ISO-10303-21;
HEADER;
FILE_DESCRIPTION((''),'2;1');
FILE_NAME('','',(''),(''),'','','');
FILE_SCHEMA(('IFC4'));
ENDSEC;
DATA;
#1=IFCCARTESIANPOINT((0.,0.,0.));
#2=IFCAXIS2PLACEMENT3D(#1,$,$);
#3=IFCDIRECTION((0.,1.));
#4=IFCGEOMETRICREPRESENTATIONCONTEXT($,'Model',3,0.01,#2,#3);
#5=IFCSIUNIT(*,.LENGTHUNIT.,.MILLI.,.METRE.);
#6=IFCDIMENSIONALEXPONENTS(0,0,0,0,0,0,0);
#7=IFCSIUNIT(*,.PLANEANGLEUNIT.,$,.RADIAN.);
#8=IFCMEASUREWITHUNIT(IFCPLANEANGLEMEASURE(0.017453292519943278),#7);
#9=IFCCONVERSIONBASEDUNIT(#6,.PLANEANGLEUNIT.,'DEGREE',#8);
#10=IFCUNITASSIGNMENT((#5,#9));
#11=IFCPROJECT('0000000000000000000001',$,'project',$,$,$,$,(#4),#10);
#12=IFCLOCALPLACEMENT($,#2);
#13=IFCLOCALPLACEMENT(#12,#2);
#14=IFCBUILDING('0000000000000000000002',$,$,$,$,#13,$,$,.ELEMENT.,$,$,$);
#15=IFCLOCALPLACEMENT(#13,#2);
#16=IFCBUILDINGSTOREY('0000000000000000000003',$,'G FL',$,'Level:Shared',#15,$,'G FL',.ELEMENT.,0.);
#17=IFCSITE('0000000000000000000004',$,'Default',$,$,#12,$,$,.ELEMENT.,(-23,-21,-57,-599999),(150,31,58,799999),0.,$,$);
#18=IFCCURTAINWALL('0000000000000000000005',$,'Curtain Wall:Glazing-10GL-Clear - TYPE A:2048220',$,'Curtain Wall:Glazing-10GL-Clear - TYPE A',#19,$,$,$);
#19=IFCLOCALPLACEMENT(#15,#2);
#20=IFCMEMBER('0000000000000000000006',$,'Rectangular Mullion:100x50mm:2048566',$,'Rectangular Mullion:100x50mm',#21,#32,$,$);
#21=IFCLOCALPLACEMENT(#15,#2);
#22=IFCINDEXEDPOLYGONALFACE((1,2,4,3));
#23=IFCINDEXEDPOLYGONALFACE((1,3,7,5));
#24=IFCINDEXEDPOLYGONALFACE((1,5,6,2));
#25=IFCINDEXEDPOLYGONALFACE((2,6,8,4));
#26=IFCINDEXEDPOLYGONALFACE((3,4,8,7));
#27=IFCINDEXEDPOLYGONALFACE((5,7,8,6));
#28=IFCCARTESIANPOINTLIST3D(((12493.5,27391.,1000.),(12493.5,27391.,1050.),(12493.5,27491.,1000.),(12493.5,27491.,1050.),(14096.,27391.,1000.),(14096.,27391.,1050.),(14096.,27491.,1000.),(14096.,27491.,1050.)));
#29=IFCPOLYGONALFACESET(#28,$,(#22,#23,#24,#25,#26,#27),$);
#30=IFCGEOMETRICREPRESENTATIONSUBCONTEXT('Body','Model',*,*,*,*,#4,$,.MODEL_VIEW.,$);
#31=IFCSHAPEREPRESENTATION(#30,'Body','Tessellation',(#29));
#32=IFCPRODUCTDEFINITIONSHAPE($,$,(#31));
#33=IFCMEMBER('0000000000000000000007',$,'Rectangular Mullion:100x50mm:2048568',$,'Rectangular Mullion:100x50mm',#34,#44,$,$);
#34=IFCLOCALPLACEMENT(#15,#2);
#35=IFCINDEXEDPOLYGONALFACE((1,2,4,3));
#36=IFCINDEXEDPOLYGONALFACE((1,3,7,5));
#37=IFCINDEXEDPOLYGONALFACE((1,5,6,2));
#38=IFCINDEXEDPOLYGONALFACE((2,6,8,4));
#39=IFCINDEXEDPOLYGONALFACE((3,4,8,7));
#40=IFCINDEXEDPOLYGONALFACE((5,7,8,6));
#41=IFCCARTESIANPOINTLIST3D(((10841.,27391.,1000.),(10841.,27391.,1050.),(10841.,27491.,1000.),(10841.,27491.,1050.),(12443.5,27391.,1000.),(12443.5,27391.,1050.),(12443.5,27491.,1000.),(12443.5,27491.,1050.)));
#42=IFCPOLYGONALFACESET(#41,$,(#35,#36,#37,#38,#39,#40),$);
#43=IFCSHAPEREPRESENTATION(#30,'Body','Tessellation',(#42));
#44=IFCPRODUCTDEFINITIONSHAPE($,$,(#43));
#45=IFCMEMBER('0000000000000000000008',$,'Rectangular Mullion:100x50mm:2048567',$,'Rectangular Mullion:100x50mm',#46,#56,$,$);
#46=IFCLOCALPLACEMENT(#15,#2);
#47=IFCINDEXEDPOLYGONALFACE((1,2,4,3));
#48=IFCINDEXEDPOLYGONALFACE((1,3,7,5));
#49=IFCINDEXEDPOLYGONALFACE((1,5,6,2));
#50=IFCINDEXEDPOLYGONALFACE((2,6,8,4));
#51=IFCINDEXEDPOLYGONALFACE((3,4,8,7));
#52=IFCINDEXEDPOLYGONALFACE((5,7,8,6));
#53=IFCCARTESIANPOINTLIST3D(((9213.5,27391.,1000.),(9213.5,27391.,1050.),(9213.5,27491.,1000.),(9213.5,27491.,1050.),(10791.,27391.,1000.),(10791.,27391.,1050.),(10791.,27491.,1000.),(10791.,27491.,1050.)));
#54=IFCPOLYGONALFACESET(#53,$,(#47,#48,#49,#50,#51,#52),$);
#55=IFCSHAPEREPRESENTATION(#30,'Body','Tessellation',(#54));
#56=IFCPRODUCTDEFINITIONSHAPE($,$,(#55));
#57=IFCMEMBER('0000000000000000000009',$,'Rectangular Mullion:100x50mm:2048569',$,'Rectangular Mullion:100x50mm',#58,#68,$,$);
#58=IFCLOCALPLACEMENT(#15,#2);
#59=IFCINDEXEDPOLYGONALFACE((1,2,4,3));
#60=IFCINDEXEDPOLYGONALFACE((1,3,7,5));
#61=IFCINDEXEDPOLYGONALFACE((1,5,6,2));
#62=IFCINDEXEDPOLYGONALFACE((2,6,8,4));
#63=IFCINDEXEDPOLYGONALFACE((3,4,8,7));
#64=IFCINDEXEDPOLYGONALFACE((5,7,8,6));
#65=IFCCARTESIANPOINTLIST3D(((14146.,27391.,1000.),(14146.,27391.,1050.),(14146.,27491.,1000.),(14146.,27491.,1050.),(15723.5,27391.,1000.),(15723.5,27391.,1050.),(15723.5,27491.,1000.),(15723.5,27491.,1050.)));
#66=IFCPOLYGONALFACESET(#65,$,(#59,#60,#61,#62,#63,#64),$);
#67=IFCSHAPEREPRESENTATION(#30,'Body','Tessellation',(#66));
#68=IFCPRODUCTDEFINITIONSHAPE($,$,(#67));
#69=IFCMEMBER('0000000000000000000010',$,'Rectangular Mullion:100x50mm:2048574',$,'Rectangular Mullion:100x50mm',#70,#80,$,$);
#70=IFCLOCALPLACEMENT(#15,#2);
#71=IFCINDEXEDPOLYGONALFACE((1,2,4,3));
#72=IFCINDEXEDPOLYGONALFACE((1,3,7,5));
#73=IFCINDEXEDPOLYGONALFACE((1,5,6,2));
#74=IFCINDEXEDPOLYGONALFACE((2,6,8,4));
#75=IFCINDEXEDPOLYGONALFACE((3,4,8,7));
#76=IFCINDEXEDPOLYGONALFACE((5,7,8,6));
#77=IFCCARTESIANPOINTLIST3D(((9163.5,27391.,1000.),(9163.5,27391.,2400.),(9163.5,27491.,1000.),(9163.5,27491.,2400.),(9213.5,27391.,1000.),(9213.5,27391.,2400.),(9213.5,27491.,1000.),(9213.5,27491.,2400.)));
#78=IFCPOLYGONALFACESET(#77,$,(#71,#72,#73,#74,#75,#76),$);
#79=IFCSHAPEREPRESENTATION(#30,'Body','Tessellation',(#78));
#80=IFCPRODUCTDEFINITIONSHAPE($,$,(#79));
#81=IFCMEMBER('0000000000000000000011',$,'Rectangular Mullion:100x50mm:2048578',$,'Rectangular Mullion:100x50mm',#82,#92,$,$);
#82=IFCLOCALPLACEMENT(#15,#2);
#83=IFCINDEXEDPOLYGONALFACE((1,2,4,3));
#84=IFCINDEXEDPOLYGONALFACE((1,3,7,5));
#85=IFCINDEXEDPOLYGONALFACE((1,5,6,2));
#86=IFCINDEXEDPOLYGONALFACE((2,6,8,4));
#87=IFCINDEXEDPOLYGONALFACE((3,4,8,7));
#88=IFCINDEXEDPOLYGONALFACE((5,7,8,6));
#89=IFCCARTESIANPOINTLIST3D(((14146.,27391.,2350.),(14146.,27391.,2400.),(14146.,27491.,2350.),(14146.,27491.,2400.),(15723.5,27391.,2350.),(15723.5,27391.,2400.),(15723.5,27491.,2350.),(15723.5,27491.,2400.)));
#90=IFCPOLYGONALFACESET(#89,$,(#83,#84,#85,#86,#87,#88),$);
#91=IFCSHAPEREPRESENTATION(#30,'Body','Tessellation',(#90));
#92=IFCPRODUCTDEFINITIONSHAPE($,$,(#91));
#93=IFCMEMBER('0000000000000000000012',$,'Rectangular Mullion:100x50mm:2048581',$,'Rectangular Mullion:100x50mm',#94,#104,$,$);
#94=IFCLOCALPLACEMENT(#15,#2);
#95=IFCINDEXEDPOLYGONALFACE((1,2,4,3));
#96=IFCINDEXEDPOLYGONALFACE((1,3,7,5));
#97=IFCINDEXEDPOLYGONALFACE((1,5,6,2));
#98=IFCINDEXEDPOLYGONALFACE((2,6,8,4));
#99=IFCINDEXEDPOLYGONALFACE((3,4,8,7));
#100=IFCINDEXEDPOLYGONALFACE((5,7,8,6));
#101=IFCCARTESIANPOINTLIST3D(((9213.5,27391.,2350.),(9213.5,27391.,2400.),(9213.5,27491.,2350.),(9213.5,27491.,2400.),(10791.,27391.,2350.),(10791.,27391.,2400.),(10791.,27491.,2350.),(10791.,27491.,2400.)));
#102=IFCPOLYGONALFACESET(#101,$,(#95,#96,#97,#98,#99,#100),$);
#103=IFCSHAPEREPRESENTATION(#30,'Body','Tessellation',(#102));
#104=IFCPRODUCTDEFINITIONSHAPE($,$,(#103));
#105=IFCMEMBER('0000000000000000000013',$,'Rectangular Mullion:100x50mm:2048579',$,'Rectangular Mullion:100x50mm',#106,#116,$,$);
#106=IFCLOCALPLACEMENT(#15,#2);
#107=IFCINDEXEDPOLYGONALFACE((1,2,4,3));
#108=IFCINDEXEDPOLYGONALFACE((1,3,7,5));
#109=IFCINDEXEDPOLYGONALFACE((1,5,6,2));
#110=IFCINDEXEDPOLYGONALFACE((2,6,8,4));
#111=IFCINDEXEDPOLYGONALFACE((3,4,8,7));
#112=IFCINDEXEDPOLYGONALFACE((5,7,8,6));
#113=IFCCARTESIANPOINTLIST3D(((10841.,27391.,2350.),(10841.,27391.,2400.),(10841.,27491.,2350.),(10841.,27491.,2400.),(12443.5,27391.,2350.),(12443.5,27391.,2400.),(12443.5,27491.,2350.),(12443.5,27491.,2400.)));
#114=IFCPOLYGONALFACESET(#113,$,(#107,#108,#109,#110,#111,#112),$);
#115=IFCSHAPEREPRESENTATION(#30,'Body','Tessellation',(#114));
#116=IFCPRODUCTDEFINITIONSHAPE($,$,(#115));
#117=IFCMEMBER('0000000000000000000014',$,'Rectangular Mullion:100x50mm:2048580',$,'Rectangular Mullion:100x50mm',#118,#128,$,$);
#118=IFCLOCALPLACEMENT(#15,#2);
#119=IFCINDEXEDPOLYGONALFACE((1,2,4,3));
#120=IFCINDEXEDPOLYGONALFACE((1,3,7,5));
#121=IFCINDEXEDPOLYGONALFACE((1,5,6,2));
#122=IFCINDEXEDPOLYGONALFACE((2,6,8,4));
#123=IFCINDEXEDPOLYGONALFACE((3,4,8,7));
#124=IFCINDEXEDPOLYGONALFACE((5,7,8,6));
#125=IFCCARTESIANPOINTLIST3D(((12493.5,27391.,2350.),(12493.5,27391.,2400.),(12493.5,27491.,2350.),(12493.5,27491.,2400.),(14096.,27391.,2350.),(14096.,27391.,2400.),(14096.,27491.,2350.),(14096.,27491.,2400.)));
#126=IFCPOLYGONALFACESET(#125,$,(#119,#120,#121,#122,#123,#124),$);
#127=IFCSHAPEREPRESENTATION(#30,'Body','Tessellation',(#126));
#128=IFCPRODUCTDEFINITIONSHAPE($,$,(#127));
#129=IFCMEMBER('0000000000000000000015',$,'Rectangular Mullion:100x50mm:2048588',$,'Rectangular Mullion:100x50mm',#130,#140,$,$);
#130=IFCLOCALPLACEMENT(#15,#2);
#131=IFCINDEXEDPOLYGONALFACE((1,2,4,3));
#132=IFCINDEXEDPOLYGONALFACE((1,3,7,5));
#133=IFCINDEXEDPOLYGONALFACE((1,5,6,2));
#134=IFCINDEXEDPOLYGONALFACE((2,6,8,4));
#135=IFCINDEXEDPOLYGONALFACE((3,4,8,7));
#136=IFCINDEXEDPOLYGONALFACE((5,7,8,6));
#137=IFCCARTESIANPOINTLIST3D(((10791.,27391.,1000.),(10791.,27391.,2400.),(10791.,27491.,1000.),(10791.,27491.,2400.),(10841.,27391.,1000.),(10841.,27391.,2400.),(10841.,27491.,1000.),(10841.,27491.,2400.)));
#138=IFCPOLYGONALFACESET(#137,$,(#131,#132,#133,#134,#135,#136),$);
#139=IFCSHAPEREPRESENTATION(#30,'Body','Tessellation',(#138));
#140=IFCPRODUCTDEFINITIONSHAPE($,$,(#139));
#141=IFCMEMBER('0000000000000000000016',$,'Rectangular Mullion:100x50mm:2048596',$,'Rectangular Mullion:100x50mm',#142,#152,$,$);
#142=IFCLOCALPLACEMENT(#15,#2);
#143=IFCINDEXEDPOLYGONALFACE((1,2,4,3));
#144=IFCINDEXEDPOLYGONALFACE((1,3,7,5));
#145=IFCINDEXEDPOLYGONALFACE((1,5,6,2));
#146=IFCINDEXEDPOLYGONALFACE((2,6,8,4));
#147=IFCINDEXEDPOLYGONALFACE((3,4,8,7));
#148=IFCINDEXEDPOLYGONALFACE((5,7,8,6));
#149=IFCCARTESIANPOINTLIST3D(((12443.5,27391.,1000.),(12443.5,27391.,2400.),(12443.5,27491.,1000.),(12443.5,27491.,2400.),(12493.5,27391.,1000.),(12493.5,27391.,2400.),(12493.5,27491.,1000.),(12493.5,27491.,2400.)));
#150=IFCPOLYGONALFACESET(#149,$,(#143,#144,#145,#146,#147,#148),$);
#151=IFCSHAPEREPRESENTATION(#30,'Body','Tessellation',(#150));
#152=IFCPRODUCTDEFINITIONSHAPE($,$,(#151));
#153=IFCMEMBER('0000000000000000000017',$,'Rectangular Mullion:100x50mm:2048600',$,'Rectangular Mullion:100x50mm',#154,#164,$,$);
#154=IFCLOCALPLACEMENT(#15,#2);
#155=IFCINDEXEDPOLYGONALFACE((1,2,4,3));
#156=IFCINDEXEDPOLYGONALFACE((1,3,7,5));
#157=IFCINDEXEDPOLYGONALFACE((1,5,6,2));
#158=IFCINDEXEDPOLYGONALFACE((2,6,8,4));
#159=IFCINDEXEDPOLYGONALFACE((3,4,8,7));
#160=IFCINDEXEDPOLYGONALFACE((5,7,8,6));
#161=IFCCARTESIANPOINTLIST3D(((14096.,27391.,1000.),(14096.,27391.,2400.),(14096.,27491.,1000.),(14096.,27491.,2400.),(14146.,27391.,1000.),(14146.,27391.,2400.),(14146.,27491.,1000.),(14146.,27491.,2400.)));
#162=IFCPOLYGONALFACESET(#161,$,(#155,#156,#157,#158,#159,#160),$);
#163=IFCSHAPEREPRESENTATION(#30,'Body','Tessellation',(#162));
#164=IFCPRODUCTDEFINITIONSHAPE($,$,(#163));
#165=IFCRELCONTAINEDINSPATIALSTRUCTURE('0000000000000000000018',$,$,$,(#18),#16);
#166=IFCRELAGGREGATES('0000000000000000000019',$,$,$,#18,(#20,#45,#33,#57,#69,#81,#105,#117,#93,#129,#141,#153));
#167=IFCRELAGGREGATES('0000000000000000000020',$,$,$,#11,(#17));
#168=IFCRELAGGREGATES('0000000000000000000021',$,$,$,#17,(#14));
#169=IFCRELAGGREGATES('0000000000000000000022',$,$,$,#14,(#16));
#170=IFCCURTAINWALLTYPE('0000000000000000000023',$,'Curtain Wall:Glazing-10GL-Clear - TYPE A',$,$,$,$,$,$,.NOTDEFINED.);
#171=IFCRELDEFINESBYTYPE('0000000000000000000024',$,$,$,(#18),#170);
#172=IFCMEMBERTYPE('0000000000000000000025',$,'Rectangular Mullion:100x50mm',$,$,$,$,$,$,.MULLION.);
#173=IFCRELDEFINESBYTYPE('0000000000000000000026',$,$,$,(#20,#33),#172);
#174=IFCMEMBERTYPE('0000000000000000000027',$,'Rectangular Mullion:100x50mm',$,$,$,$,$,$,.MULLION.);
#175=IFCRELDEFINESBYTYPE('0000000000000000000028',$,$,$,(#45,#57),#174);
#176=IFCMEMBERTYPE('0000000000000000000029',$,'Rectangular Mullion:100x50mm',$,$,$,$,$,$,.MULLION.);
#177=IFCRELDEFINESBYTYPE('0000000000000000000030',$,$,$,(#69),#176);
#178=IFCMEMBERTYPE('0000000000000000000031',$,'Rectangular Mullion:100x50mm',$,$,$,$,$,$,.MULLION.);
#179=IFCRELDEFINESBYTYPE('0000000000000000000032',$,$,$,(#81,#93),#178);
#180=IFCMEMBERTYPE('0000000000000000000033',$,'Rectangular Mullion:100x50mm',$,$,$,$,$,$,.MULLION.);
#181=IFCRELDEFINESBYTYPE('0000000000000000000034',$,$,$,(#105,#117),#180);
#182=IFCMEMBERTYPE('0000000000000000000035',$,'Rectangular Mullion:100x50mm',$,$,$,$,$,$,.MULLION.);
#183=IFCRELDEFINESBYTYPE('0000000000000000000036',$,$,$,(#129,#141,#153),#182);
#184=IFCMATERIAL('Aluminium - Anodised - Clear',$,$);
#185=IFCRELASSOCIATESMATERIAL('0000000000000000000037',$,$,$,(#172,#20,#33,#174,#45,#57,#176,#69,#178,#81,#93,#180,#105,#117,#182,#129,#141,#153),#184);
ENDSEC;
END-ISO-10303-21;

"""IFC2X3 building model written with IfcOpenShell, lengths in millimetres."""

from ifc_helpers import new_model, entity, si_unit, converted_unit, direction, frame, frame_2d, origin, origin_2d_with_axis, place, context, subcontext, project, spatial, rectangle, extrude, source, transform, mapped, material, type_object, type_shapes, element, aggregate, save


model = new_model("IFC2X3")

# Units and contexts
model_context = context("Model", 3, precision=0.01, world=origin(), true_north=direction((0.0, 1.0)))
body_context = subcontext(model_context, "Body", "Model", "MODEL_VIEW")
ifc_project = project(units=[si_unit("LENGTHUNIT", "METRE", prefix="MILLI"), converted_unit("PLANEANGLEUNIT", "DEGREE", entity("IfcPlaneAngleMeasure", 0.017453292519943278), si_unit("PLANEANGLEUNIT", "RADIAN"), dimensions=[0, 0, 0, 0, 0, 0, 0])], contexts=[model_context])

# Site, building, storey
site_placement = place(None, origin())
site = spatial("IfcSite", under=ifc_project, at=site_placement, Name="Default", CompositionType="ELEMENT", RefLatitude=(-23, -21, -57, -599999), RefLongitude=(150, 31, 58, 799999), RefElevation=0.0)
building_placement = place(site_placement, origin())
building = spatial("IfcBuilding", under=site, at=building_placement, CompositionType="ELEMENT")
storey_placement = place(building_placement, origin())
storey = spatial("IfcBuildingStorey", under=building, at=storey_placement, Name="G FL", ObjectType="Level:Shared", LongName="G FL", CompositionType="ELEMENT", Elevation=0.0)

# Curtain wall, members
curtain_wall_type = type_object("IfcCurtainWallType", Name="Curtain Wall:Glazing-10GL-Clear - TYPE A", PredefinedType="NOTDEFINED")
curtain_wall_placement = place(storey_placement, origin())
curtain_wall = element("IfcCurtainWall", 1, at=curtain_wall_placement, inside=storey, type_object=curtain_wall_type, Name="Curtain Wall:Glazing-10GL-Clear - TYPE A:2048220", ObjectType="Curtain Wall:Glazing-10GL-Clear - TYPE A")
ifc_material_1 = material(Name="Aluminium - Anodised - Clear")
member_type_1 = type_object("IfcMemberType", Name="Rectangular Mullion:100x50mm", PredefinedType="MULLION", material=ifc_material_1)
shared_shape_1 = source(origin(), body_context, "Body", "SweptSolid", [
    extrude(rectangle(XDim=50.0, YDim=100.0, at=frame_2d((0.0, 0.0), x_axis=(1.0, 0.0))), frame((-25.0, 0.0, -1602.5), z_axis=(0.0, 0.0, 1.0), x_axis=(-1.0, 0.0, 0.0)), (0.0, 0.0, 1.0), 1602.5),
])
type_shapes(member_type_1, [shared_shape_1])
member_1_placement = place(curtain_wall_placement, frame((14096.0, 27441.0, 1000.0), z_axis=(1.0, 0.0, 0.0), x_axis=(0.0, 0.0, -1.0)))
member_1 = element("IfcMember", 2, at=member_1_placement, type_object=member_type_1, material=ifc_material_1, Name="Rectangular Mullion:100x50mm:2048566", ObjectType="Rectangular Mullion:100x50mm", context=body_context, shape_type="MappedRepresentation", body=[
    mapped(shared_shape_1, transform((0.0, 0.0, 0.0), scale=1.0)),
])
member_2_placement = place(curtain_wall_placement, frame((12443.5, 27441.0, 1000.0), z_axis=(1.0, 0.0, 0.0), x_axis=(0.0, 0.0, -1.0)))
member_2 = element("IfcMember", 3, at=member_2_placement, type_object=member_type_1, material=ifc_material_1, Name="Rectangular Mullion:100x50mm:2048568", ObjectType="Rectangular Mullion:100x50mm", context=body_context, shape_type="MappedRepresentation", body=[
    mapped(shared_shape_1, transform((0.0, 0.0, 0.0), scale=1.0)),
])
member_type_2 = type_object("IfcMemberType", Name="Rectangular Mullion:100x50mm", PredefinedType="MULLION", material=ifc_material_1)
shared_shape_2 = source(origin(), body_context, "Body", "SweptSolid", [
    extrude(rectangle(XDim=50.0, YDim=100.0, at=frame_2d((0.0, 0.0), x_axis=(1.0, 0.0))), frame((-25.0, 0.0, -1577.5), z_axis=(0.0, 0.0, 1.0), x_axis=(-1.0, 0.0, 0.0)), (0.0, 0.0, 1.0), 1577.5),
])
type_shapes(member_type_2, [shared_shape_2])
member_3_placement = place(curtain_wall_placement, frame((10791.0, 27441.0, 1000.0), z_axis=(1.0, 0.0, 0.0), x_axis=(0.0, 0.0, -1.0)))
member_3 = element("IfcMember", 4, at=member_3_placement, type_object=member_type_2, material=ifc_material_1, Name="Rectangular Mullion:100x50mm:2048567", ObjectType="Rectangular Mullion:100x50mm", context=body_context, shape_type="MappedRepresentation", body=[
    mapped(shared_shape_2, transform((0.0, 0.0, 0.0), scale=1.0)),
])
member_4_placement = place(curtain_wall_placement, frame((15723.5, 27441.0, 1000.0), z_axis=(1.0, 0.0, 0.0), x_axis=(0.0, 0.0, -1.0)))
member_4 = element("IfcMember", 5, at=member_4_placement, type_object=member_type_2, material=ifc_material_1, Name="Rectangular Mullion:100x50mm:2048569", ObjectType="Rectangular Mullion:100x50mm", context=body_context, shape_type="MappedRepresentation", body=[
    mapped(shared_shape_2, transform((0.0, 0.0, 0.0), scale=1.0)),
])
member_type_3 = type_object("IfcMemberType", Name="Rectangular Mullion:100x50mm", PredefinedType="MULLION", material=ifc_material_1)
shared_shape_3 = source(origin(), body_context, "Body", "SweptSolid", [
    extrude(rectangle(XDim=50.0, YDim=100.0, at=origin_2d_with_axis()), frame((-25.0, 0.0, -1400.0), z_axis=(0.0, 0.0, 1.0), x_axis=(-1.0, 0.0, 0.0)), (0.0, 0.0, 1.0), 1400.0),
])
type_shapes(member_type_3, [shared_shape_3])
member_5_placement = place(curtain_wall_placement, frame((9163.5, 27441.0, 1000.0), z_axis=(0.0, 0.0, -1.0), x_axis=(-1.0, 0.0, 0.0)))
member_5 = element("IfcMember", 6, at=member_5_placement, type_object=member_type_3, material=ifc_material_1, Name="Rectangular Mullion:100x50mm:2048574", ObjectType="Rectangular Mullion:100x50mm", context=body_context, shape_type="MappedRepresentation", body=[
    mapped(shared_shape_3, transform((0.0, 0.0, 0.0), scale=1.0)),
])
member_type_4 = type_object("IfcMemberType", Name="Rectangular Mullion:100x50mm", PredefinedType="MULLION", material=ifc_material_1)
shared_shape_4 = source(origin(), body_context, "Body", "SweptSolid", [
    extrude(rectangle(XDim=50.0, YDim=100.0, at=frame_2d((0.0, 0.0), x_axis=(1.0, 0.0))), frame((-25.0, 0.0, -1577.5), z_axis=(0.0, 0.0, 1.0), x_axis=(-1.0, 0.0, 0.0)), (0.0, 0.0, 1.0), 1577.5),
])
type_shapes(member_type_4, [shared_shape_4])
member_6_placement = place(curtain_wall_placement, frame((14146.0, 27441.0, 2400.0), z_axis=(-1.0, 0.0, 0.0), x_axis=(0.0, 0.0, 1.0)))
member_6 = element("IfcMember", 7, at=member_6_placement, type_object=member_type_4, material=ifc_material_1, Name="Rectangular Mullion:100x50mm:2048578", ObjectType="Rectangular Mullion:100x50mm", context=body_context, shape_type="MappedRepresentation", body=[
    mapped(shared_shape_4, transform((0.0, 0.0, 0.0), scale=1.0)),
])
member_7_placement = place(curtain_wall_placement, frame((9213.5, 27441.0, 2400.0), z_axis=(-1.0, 0.0, 0.0), x_axis=(0.0, 0.0, 1.0)))
member_7 = element("IfcMember", 8, at=member_7_placement, type_object=member_type_4, material=ifc_material_1, Name="Rectangular Mullion:100x50mm:2048581", ObjectType="Rectangular Mullion:100x50mm", context=body_context, shape_type="MappedRepresentation", body=[
    mapped(shared_shape_4, transform((0.0, 0.0, 0.0), scale=1.0)),
])
member_type_5 = type_object("IfcMemberType", Name="Rectangular Mullion:100x50mm", PredefinedType="MULLION", material=ifc_material_1)
shared_shape_5 = source(origin(), body_context, "Body", "SweptSolid", [
    extrude(rectangle(XDim=50.0, YDim=100.0, at=frame_2d((0.0, 0.0), x_axis=(1.0, 0.0))), frame((-25.0, 0.0, -1602.5), z_axis=(0.0, 0.0, 1.0), x_axis=(-1.0, 0.0, 0.0)), (0.0, 0.0, 1.0), 1602.5),
])
type_shapes(member_type_5, [shared_shape_5])
member_8_placement = place(curtain_wall_placement, frame((10841.0, 27441.0, 2400.0), z_axis=(-1.0, 0.0, 0.0), x_axis=(0.0, 0.0, 1.0)))
member_8 = element("IfcMember", 9, at=member_8_placement, type_object=member_type_5, material=ifc_material_1, Name="Rectangular Mullion:100x50mm:2048579", ObjectType="Rectangular Mullion:100x50mm", context=body_context, shape_type="MappedRepresentation", body=[
    mapped(shared_shape_5, transform((0.0, 0.0, 0.0), scale=1.0)),
])
member_9_placement = place(curtain_wall_placement, frame((12493.5, 27441.0, 2400.0), z_axis=(-1.0, 0.0, 0.0), x_axis=(0.0, 0.0, 1.0)))
member_9 = element("IfcMember", 10, at=member_9_placement, type_object=member_type_5, material=ifc_material_1, Name="Rectangular Mullion:100x50mm:2048580", ObjectType="Rectangular Mullion:100x50mm", context=body_context, shape_type="MappedRepresentation", body=[
    mapped(shared_shape_5, transform((0.0, 0.0, 0.0), scale=1.0)),
])
member_type_6 = type_object("IfcMemberType", Name="Rectangular Mullion:100x50mm", PredefinedType="MULLION", material=ifc_material_1)
shared_shape_6 = source(origin(), body_context, "Body", "SweptSolid", [
    extrude(rectangle(XDim=50.0, YDim=100.0, at=frame_2d((0.0, 0.0), x_axis=(1.0, 0.0))), frame((0.0, 0.0, -1400.0), z_axis=(0.0, 0.0, 1.0), x_axis=(-1.0, 0.0, 0.0)), (0.0, 0.0, 1.0), 1400.0),
])
type_shapes(member_type_6, [shared_shape_6])
member_10_placement = place(curtain_wall_placement, frame((10816.0, 27441.0, 1000.0), z_axis=(0.0, 0.0, -1.0), x_axis=(-1.0, 0.0, 0.0)))
member_10 = element("IfcMember", 11, at=member_10_placement, type_object=member_type_6, material=ifc_material_1, Name="Rectangular Mullion:100x50mm:2048588", ObjectType="Rectangular Mullion:100x50mm", context=body_context, shape_type="MappedRepresentation", body=[
    mapped(shared_shape_6, transform((0.0, 0.0, 0.0), scale=1.0)),
])
member_11_placement = place(curtain_wall_placement, frame((12468.5, 27441.0, 1000.0), z_axis=(0.0, 0.0, -1.0), x_axis=(-1.0, 0.0, 0.0)))
member_11 = element("IfcMember", 12, at=member_11_placement, type_object=member_type_6, material=ifc_material_1, Name="Rectangular Mullion:100x50mm:2048596", ObjectType="Rectangular Mullion:100x50mm", context=body_context, shape_type="MappedRepresentation", body=[
    mapped(shared_shape_6, transform((0.0, 0.0, 0.0), scale=1.0)),
])
member_12_placement = place(curtain_wall_placement, frame((14121.0, 27441.0, 1000.0), z_axis=(0.0, 0.0, -1.0), x_axis=(-1.0, 0.0, 0.0)))
member_12 = element("IfcMember", 13, at=member_12_placement, type_object=member_type_6, material=ifc_material_1, Name="Rectangular Mullion:100x50mm:2048600", ObjectType="Rectangular Mullion:100x50mm", context=body_context, shape_type="MappedRepresentation", body=[
    mapped(shared_shape_6, transform((0.0, 0.0, 0.0), scale=1.0)),
])
aggregate(curtain_wall, [member_1, member_3, member_2, member_4, member_5, member_6, member_8, member_9, member_7, member_10, member_11, member_12])

save(model, "model.ifc")
